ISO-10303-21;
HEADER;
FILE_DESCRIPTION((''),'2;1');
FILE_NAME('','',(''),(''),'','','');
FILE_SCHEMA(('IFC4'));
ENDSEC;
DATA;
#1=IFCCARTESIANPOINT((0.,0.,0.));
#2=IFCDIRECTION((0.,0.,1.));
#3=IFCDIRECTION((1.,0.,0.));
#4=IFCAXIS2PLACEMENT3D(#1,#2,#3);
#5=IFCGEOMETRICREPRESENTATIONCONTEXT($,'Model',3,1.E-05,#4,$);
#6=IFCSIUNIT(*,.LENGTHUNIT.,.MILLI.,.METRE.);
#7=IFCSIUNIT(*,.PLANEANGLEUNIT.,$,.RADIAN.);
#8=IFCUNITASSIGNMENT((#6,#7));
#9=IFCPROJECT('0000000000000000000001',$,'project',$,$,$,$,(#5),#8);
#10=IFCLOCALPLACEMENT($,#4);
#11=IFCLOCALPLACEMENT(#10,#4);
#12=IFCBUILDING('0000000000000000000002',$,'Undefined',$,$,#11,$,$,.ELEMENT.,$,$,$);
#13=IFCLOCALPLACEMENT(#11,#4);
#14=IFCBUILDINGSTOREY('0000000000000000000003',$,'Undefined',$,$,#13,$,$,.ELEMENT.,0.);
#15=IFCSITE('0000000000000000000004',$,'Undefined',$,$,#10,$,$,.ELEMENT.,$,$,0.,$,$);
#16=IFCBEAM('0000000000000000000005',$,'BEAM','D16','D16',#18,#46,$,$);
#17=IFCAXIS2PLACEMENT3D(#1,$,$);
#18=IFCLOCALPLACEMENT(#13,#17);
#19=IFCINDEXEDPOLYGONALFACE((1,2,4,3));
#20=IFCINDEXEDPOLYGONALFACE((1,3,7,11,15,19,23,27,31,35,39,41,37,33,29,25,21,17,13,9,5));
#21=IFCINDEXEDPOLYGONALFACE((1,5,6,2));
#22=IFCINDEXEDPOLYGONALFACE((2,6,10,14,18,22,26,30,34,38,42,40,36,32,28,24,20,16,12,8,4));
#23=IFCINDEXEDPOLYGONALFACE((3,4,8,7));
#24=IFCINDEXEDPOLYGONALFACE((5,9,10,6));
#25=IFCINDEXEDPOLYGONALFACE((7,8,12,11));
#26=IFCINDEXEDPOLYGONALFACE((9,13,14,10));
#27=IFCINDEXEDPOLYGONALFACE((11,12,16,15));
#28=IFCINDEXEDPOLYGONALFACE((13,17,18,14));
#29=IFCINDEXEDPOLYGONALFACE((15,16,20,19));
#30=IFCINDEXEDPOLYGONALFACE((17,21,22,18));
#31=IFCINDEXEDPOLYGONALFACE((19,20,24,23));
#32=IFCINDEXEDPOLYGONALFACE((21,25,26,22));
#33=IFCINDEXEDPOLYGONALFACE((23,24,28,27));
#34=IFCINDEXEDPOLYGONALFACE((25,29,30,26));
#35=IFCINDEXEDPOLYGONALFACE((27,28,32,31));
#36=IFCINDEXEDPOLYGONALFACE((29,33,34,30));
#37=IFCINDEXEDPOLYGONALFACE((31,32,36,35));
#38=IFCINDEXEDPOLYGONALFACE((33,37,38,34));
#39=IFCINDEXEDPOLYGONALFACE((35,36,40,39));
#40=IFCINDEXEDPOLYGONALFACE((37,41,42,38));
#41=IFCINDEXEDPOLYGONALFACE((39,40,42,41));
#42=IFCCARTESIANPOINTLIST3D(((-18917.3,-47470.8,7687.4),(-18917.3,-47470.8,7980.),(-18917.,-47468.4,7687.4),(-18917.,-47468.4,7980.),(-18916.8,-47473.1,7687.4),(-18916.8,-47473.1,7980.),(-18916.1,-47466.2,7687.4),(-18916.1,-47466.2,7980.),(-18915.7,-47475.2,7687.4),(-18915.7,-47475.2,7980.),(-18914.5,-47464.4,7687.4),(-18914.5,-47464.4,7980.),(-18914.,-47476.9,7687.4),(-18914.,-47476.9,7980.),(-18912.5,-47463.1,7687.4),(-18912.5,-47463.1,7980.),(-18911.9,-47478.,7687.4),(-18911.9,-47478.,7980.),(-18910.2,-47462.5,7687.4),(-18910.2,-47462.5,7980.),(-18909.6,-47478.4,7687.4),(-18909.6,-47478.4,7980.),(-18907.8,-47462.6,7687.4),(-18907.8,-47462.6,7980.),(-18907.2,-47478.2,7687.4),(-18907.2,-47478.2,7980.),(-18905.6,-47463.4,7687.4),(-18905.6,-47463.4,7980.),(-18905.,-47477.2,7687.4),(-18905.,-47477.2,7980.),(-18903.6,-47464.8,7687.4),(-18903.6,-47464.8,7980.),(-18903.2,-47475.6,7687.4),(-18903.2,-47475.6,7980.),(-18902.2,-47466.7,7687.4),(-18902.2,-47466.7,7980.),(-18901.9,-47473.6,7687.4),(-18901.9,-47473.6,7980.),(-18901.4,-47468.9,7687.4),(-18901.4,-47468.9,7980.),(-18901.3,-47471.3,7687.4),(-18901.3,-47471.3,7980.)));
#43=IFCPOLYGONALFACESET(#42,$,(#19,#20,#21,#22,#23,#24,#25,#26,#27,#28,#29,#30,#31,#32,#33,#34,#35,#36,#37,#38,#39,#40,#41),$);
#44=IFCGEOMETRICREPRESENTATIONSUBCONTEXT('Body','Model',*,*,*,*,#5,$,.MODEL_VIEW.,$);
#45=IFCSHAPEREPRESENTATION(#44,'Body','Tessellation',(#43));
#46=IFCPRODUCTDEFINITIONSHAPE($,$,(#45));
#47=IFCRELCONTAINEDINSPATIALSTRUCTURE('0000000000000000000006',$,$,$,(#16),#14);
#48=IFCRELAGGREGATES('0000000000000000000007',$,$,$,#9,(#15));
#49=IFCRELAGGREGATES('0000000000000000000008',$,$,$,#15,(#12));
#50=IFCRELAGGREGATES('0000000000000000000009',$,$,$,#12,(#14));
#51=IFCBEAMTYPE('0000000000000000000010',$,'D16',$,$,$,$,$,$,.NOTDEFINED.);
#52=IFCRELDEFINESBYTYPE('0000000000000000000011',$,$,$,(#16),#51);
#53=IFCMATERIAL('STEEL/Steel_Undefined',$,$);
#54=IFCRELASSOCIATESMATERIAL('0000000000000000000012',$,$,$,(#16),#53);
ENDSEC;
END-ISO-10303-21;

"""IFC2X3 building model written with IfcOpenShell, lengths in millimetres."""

from ifc_helpers import new_model, si_unit, frame, origin_with_axes, origin_2d_with_axis, place, context, subcontext, project, spatial, circle, extrude, material, type_object, element, save


model = new_model("IFC2X3")

# Units and contexts
model_context = context("Model", 3, precision=1e-05, world=origin_with_axes())
body_context = subcontext(model_context, "Body", "Model", "MODEL_VIEW")
ifc_project = project(units=[si_unit("LENGTHUNIT", "METRE", prefix="MILLI"), si_unit("PLANEANGLEUNIT", "RADIAN")], contexts=[model_context])

# Site, building, storey
site_placement = place(None, origin_with_axes())
site = spatial("IfcSite", under=ifc_project, at=site_placement, Name="Undefined", CompositionType="ELEMENT", RefElevation=0.0)
building_placement = place(site_placement, origin_with_axes())
building = spatial("IfcBuilding", under=site, at=building_placement, Name="Undefined", CompositionType="ELEMENT")
storey_placement = place(building_placement, origin_with_axes())
storey = spatial("IfcBuildingStorey", under=building, at=storey_placement, Name="Undefined", CompositionType="ELEMENT", Elevation=0.0)

# Shared definitions
ifc_material = material(Name="STEEL/Steel_Undefined")

# Beam
beam_type_1 = type_object("IfcBeamType", Name="D16", PredefinedType="NOTDEFINED")
for number, where, z_axis, x_axis, name in (
    (1, (-18909.3, -47470.4, 7980.0), (-0.915553, -0.402197, 0.0), (0.0, 0.0, -1.0), "BEAM"),
):
    element("IfcBeam", number, at=place(storey_placement, frame(where, z_axis=z_axis, x_axis=x_axis)), inside=storey, type_object=beam_type_1, material=ifc_material, Name=name, Description="D16", ObjectType="D16", context=body_context, shape_type="SweptSolid", body=[
        extrude(circle(Radius=8.0, at=origin_2d_with_axis()), frame((292.6, 0.0, 0.0), z_axis=(-1.0, 0.0, 0.0), x_axis=(0.0, -1.0, 0.0)), (0.0, 0.0, 1.0), 292.6),
    ])

save(model, "model.ifc")
